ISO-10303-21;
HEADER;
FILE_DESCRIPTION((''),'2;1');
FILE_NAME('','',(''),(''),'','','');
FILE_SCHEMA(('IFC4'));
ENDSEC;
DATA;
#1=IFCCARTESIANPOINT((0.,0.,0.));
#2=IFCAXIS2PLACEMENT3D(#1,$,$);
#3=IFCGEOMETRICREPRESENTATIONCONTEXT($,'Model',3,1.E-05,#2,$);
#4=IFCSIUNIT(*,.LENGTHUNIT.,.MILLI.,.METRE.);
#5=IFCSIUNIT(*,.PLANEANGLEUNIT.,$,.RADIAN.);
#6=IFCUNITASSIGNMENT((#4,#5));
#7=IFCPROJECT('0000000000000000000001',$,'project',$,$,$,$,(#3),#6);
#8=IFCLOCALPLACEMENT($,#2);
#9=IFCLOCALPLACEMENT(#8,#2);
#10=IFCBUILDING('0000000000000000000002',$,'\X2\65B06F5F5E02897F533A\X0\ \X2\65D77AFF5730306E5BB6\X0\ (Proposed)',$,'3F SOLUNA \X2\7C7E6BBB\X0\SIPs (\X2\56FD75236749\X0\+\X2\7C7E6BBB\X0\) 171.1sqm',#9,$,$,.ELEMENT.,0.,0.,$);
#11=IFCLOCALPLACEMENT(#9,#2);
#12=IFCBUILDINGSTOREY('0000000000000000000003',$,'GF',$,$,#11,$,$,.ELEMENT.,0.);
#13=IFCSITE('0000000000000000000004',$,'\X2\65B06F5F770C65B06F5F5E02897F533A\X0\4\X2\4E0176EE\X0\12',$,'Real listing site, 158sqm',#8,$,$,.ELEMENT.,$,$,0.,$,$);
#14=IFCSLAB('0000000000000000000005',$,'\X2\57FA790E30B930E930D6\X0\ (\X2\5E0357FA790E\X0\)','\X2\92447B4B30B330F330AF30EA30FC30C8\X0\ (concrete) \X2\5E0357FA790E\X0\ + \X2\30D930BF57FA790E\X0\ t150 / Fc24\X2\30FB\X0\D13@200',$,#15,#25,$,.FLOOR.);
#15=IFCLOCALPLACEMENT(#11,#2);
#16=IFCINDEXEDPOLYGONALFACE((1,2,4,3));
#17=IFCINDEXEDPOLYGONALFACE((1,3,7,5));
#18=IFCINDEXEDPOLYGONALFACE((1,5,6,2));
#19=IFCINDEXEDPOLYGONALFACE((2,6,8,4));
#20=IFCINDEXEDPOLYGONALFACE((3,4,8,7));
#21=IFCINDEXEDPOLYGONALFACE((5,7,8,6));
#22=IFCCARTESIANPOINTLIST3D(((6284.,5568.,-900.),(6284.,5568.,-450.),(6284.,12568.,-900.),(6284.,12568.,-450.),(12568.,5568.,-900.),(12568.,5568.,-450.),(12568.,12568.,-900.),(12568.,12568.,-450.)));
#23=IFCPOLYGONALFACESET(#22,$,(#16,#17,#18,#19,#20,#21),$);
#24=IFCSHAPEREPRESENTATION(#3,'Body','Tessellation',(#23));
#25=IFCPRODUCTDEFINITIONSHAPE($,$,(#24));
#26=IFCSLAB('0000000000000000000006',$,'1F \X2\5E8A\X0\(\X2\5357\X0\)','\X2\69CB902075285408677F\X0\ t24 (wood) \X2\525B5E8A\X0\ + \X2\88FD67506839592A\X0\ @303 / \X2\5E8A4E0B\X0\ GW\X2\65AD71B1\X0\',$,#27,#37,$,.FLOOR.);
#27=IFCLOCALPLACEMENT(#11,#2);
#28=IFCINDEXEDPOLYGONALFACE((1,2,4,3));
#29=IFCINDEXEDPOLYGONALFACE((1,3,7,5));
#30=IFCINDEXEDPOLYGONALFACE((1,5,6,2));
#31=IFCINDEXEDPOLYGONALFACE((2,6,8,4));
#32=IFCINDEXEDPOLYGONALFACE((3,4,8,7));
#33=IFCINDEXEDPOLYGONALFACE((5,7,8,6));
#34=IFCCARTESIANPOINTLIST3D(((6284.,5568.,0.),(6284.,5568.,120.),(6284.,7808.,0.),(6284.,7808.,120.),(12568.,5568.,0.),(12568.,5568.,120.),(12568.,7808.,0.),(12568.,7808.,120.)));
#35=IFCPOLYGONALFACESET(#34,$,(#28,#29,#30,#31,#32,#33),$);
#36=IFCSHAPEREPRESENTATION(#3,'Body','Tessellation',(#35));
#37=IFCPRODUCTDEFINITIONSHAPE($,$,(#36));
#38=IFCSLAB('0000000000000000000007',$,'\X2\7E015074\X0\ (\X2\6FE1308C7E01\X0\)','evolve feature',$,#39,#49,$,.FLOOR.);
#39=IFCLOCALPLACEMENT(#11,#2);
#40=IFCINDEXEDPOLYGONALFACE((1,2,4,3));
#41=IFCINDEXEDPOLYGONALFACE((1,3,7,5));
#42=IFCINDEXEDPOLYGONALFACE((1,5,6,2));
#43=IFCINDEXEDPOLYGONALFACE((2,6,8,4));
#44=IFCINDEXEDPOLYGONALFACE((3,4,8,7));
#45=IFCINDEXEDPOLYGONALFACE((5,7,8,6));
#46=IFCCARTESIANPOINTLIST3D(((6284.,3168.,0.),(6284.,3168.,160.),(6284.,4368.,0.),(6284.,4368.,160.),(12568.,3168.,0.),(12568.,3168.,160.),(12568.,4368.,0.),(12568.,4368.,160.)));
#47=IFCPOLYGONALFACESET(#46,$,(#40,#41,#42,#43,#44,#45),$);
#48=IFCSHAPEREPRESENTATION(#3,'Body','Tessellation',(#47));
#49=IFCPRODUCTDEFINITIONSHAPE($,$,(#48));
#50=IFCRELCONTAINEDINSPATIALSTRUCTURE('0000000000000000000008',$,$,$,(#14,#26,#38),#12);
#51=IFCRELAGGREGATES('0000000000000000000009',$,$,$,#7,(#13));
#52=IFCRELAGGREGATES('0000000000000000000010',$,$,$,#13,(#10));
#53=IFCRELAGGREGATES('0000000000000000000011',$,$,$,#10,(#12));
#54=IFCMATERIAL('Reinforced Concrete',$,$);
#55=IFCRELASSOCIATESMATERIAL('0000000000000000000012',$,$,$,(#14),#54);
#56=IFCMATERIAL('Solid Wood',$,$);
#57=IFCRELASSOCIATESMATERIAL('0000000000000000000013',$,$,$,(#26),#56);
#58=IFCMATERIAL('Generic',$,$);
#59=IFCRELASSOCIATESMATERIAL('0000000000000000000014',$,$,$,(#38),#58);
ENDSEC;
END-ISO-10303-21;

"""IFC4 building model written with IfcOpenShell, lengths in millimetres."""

from ifc_helpers import new_model, si_unit, frame, frame_2d, origin, place, context, project, spatial, rectangle, extrude, material, element, save


model = new_model("IFC4")

# Units and contexts
model_context = context("Model", 3, precision=1e-05, world=origin())
ifc_project = project(units=[si_unit("LENGTHUNIT", "METRE", prefix="MILLI"), si_unit("PLANEANGLEUNIT", "RADIAN")], contexts=[model_context])

# Site, building, storey
site_placement = place(None, origin())
site = spatial("IfcSite", under=ifc_project, at=site_placement, Name="新潟県新潟市西区4丁目12", ObjectType="Real listing site, 158sqm", CompositionType="ELEMENT", RefElevation=0.0)
building_placement = place(site_placement, origin())
building = spatial("IfcBuilding", under=site, at=building_placement, Name="新潟市西区 旗竿地の家 (Proposed)", ObjectType="3F SOLUNA 籾殻SIPs (国産杉+籾殻) 171.1sqm", CompositionType="ELEMENT", ElevationOfRefHeight=0.0, ElevationOfTerrain=0.0)
storey_placement = place(building_placement, origin())
storey = spatial("IfcBuildingStorey", under=building, at=storey_placement, Name="GF", CompositionType="ELEMENT", Elevation=0.0)

# Slabs
ifc_material_1 = material(Name="Reinforced Concrete")
slab_1_placement = place(storey_placement, frame((3142.0, 2784.0, -450.0)))
element("IfcSlab", 1, at=slab_1_placement, inside=storey, material=ifc_material_1, Name="基礎スラブ (布基礎)", Description="鉄筋コンクリート (concrete) 布基礎 + ベタ基礎 t150 / Fc24・D13@200", PredefinedType="FLOOR", context=model_context, shape_type="SweptSolid", body=[
    extrude(rectangle(XDim=6284.0, YDim=7000.0, at=frame_2d((3142.0, 3500.0))), frame((3142.0, 2784.0, -450.0)), (0.0, 0.0, 1.0), 450.0),
])
ifc_material_2 = material(Name="Solid Wood")
slab_2_placement = place(storey_placement, frame((3142.0, 2784.0, 0.0)))
element("IfcSlab", 2, at=slab_2_placement, inside=storey, material=ifc_material_2, Name="1F 床(南)", Description="構造用合板 t24 (wood) 剛床 + 製材根太 @303 / 床下 GW断熱", PredefinedType="FLOOR", context=model_context, shape_type="SweptSolid", body=[
    extrude(rectangle(XDim=6284.0, YDim=2240.0, at=frame_2d((3142.0, 1120.0))), frame((3142.0, 2784.0, 0.0)), (0.0, 0.0, 1.0), 120.0),
])
ifc_material_3 = material(Name="Generic")
slab_3_placement = place(storey_placement, frame((3142.0, 1584.0, 0.0)))
element("IfcSlab", 3, at=slab_3_placement, inside=storey, material=ifc_material_3, Name="縁側 (濡れ縁)", Description="evolve feature", PredefinedType="FLOOR", context=model_context, shape_type="SweptSolid", body=[
    extrude(rectangle(XDim=6284.0, YDim=1200.0, at=frame_2d((3142.0, 600.0))), frame((3142.0, 1584.0, 0.0)), (0.0, 0.0, 1.0), 160.0),
])

save(model, "model.ifc")
